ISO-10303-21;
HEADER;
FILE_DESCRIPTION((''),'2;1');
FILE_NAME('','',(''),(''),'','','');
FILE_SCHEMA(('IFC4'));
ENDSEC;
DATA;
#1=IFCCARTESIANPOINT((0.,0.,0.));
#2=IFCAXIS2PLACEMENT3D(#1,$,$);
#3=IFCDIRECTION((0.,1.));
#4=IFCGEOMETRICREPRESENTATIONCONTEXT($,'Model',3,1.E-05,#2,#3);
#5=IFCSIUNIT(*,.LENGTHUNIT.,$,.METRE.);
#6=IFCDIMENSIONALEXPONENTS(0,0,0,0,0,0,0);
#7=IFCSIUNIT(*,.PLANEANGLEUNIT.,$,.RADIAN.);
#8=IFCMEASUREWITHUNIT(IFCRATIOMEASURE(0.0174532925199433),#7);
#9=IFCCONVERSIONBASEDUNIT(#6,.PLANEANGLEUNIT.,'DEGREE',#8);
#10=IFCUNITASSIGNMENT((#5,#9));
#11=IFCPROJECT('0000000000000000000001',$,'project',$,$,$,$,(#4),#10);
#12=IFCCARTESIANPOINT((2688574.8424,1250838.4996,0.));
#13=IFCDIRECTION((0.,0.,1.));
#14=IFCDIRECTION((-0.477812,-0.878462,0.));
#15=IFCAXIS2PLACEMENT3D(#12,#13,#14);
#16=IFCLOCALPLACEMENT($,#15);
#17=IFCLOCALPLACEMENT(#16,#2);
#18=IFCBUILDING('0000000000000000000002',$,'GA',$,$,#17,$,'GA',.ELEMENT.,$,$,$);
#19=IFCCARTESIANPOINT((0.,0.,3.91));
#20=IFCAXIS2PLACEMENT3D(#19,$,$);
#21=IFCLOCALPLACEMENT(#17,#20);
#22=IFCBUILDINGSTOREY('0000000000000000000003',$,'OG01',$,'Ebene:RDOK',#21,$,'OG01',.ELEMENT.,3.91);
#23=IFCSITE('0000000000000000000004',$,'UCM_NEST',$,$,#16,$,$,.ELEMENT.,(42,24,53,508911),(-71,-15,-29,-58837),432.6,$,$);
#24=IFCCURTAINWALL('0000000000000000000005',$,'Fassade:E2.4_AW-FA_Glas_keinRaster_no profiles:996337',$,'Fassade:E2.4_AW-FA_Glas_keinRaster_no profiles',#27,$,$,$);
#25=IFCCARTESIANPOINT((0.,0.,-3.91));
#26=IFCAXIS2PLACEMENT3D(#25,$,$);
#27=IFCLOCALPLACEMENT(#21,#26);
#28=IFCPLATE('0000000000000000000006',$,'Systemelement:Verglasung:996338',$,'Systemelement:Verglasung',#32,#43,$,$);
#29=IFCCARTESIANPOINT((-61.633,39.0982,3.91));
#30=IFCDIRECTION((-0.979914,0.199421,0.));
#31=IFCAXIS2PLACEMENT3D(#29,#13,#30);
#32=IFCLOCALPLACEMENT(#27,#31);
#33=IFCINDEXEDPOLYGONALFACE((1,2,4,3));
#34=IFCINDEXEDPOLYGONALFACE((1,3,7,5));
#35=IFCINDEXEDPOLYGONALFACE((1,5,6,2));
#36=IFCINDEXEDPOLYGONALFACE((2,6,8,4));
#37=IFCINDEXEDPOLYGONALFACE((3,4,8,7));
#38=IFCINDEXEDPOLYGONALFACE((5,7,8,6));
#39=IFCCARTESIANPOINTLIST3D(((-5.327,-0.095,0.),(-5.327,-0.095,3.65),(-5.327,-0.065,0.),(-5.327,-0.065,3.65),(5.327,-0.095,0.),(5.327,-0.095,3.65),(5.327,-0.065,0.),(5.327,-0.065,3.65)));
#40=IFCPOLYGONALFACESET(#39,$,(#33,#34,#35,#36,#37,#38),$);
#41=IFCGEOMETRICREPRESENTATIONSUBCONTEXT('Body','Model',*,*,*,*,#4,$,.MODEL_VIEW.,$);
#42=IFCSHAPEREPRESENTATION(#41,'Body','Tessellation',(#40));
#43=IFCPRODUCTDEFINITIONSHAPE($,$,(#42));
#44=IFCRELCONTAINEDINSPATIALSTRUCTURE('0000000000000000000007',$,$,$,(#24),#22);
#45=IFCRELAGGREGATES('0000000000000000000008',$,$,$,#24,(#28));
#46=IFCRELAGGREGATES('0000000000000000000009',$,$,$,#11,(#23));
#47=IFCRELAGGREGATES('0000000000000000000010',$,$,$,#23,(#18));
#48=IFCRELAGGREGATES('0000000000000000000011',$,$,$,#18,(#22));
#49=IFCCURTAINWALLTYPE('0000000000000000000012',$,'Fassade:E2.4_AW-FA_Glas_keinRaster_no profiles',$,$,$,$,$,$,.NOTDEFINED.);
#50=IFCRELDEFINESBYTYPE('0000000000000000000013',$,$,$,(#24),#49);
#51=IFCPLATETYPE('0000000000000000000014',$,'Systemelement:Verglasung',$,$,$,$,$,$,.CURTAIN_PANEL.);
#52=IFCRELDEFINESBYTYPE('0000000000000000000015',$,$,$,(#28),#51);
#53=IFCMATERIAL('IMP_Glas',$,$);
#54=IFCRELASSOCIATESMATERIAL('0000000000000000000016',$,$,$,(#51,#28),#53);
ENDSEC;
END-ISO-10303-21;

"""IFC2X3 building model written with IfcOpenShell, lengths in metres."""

from ifc_helpers import new_model, entity, si_unit, converted_unit, direction, frame, frame_2d, origin, place, context, subcontext, project, spatial, rectangle, extrude, source, transform, mapped, material, type_object, type_shapes, element, aggregate, save


model = new_model("IFC2X3")

# Units and contexts
model_context = context("Model", 3, precision=1e-05, world=origin(), true_north=direction((0.0, 1.0)))
body_context = subcontext(model_context, "Body", "Model", "MODEL_VIEW")
ifc_project = project(units=[si_unit("LENGTHUNIT", "METRE"), converted_unit("PLANEANGLEUNIT", "DEGREE", entity("IfcRatioMeasure", 0.0174532925199433), si_unit("PLANEANGLEUNIT", "RADIAN"), dimensions=[0, 0, 0, 0, 0, 0, 0])], contexts=[model_context])

# Site, building, storey
site_placement = place(None, frame((2688574.8424, 1250838.4996, 0.0), z_axis=(0.0, 0.0, 1.0), x_axis=(-0.477812, -0.878462, 0.0)))
site = spatial("IfcSite", under=ifc_project, at=site_placement, Name="UCM_NEST", CompositionType="ELEMENT", RefLatitude=(42, 24, 53, 508911), RefLongitude=(-71, -15, -29, -58837), RefElevation=432.6)
building_placement = place(site_placement, origin())
building = spatial("IfcBuilding", under=site, at=building_placement, Name="GA", LongName="GA", CompositionType="ELEMENT")
storey_placement = place(building_placement, frame((0.0, 0.0, 3.91)))
storey = spatial("IfcBuildingStorey", under=building, at=storey_placement, Name="OG01", ObjectType="Ebene:RDOK", LongName="OG01", CompositionType="ELEMENT", Elevation=3.91)

# Curtain wall, plate
curtain_wall_type = type_object("IfcCurtainWallType", Name="Fassade:E2.4_AW-FA_Glas_keinRaster_no profiles", PredefinedType="NOTDEFINED")
curtain_wall_placement = place(storey_placement, frame((0.0, 0.0, -3.91)))
curtain_wall = element("IfcCurtainWall", 1, at=curtain_wall_placement, inside=storey, type_object=curtain_wall_type, Name="Fassade:E2.4_AW-FA_Glas_keinRaster_no profiles:996337", ObjectType="Fassade:E2.4_AW-FA_Glas_keinRaster_no profiles")
ifc_material_1 = material(Name="IMP_Glas")
plate_type = type_object("IfcPlateType", Name="Systemelement:Verglasung", PredefinedType="CURTAIN_PANEL", material=ifc_material_1)
shared_shape_1 = source(origin(), body_context, "Body", "SweptSolid", [
    extrude(rectangle(XDim=0.03, YDim=10.654, at=frame_2d((0.0, 0.0), x_axis=(1.0, 0.0))), frame((0.0, -0.08, 0.0), z_axis=(0.0, 0.0, 1.0), x_axis=(0.0, 1.0, 0.0)), (0.0, 0.0, 1.0), 3.65),
])
type_shapes(plate_type, [shared_shape_1])
plate_placement = place(curtain_wall_placement, frame((-61.633, 39.0982, 3.91), z_axis=(0.0, 0.0, 1.0), x_axis=(-0.979914, 0.199421, 0.0)))
plate = element("IfcPlate", 2, at=plate_placement, type_object=plate_type, material=ifc_material_1, Name="Systemelement:Verglasung:996338", ObjectType="Systemelement:Verglasung", context=body_context, shape_type="MappedRepresentation", body=[
    mapped(shared_shape_1, transform((0.0, 0.0, 0.0), scale=1.0)),
])
aggregate(curtain_wall, [plate])

save(model, "model.ifc")
